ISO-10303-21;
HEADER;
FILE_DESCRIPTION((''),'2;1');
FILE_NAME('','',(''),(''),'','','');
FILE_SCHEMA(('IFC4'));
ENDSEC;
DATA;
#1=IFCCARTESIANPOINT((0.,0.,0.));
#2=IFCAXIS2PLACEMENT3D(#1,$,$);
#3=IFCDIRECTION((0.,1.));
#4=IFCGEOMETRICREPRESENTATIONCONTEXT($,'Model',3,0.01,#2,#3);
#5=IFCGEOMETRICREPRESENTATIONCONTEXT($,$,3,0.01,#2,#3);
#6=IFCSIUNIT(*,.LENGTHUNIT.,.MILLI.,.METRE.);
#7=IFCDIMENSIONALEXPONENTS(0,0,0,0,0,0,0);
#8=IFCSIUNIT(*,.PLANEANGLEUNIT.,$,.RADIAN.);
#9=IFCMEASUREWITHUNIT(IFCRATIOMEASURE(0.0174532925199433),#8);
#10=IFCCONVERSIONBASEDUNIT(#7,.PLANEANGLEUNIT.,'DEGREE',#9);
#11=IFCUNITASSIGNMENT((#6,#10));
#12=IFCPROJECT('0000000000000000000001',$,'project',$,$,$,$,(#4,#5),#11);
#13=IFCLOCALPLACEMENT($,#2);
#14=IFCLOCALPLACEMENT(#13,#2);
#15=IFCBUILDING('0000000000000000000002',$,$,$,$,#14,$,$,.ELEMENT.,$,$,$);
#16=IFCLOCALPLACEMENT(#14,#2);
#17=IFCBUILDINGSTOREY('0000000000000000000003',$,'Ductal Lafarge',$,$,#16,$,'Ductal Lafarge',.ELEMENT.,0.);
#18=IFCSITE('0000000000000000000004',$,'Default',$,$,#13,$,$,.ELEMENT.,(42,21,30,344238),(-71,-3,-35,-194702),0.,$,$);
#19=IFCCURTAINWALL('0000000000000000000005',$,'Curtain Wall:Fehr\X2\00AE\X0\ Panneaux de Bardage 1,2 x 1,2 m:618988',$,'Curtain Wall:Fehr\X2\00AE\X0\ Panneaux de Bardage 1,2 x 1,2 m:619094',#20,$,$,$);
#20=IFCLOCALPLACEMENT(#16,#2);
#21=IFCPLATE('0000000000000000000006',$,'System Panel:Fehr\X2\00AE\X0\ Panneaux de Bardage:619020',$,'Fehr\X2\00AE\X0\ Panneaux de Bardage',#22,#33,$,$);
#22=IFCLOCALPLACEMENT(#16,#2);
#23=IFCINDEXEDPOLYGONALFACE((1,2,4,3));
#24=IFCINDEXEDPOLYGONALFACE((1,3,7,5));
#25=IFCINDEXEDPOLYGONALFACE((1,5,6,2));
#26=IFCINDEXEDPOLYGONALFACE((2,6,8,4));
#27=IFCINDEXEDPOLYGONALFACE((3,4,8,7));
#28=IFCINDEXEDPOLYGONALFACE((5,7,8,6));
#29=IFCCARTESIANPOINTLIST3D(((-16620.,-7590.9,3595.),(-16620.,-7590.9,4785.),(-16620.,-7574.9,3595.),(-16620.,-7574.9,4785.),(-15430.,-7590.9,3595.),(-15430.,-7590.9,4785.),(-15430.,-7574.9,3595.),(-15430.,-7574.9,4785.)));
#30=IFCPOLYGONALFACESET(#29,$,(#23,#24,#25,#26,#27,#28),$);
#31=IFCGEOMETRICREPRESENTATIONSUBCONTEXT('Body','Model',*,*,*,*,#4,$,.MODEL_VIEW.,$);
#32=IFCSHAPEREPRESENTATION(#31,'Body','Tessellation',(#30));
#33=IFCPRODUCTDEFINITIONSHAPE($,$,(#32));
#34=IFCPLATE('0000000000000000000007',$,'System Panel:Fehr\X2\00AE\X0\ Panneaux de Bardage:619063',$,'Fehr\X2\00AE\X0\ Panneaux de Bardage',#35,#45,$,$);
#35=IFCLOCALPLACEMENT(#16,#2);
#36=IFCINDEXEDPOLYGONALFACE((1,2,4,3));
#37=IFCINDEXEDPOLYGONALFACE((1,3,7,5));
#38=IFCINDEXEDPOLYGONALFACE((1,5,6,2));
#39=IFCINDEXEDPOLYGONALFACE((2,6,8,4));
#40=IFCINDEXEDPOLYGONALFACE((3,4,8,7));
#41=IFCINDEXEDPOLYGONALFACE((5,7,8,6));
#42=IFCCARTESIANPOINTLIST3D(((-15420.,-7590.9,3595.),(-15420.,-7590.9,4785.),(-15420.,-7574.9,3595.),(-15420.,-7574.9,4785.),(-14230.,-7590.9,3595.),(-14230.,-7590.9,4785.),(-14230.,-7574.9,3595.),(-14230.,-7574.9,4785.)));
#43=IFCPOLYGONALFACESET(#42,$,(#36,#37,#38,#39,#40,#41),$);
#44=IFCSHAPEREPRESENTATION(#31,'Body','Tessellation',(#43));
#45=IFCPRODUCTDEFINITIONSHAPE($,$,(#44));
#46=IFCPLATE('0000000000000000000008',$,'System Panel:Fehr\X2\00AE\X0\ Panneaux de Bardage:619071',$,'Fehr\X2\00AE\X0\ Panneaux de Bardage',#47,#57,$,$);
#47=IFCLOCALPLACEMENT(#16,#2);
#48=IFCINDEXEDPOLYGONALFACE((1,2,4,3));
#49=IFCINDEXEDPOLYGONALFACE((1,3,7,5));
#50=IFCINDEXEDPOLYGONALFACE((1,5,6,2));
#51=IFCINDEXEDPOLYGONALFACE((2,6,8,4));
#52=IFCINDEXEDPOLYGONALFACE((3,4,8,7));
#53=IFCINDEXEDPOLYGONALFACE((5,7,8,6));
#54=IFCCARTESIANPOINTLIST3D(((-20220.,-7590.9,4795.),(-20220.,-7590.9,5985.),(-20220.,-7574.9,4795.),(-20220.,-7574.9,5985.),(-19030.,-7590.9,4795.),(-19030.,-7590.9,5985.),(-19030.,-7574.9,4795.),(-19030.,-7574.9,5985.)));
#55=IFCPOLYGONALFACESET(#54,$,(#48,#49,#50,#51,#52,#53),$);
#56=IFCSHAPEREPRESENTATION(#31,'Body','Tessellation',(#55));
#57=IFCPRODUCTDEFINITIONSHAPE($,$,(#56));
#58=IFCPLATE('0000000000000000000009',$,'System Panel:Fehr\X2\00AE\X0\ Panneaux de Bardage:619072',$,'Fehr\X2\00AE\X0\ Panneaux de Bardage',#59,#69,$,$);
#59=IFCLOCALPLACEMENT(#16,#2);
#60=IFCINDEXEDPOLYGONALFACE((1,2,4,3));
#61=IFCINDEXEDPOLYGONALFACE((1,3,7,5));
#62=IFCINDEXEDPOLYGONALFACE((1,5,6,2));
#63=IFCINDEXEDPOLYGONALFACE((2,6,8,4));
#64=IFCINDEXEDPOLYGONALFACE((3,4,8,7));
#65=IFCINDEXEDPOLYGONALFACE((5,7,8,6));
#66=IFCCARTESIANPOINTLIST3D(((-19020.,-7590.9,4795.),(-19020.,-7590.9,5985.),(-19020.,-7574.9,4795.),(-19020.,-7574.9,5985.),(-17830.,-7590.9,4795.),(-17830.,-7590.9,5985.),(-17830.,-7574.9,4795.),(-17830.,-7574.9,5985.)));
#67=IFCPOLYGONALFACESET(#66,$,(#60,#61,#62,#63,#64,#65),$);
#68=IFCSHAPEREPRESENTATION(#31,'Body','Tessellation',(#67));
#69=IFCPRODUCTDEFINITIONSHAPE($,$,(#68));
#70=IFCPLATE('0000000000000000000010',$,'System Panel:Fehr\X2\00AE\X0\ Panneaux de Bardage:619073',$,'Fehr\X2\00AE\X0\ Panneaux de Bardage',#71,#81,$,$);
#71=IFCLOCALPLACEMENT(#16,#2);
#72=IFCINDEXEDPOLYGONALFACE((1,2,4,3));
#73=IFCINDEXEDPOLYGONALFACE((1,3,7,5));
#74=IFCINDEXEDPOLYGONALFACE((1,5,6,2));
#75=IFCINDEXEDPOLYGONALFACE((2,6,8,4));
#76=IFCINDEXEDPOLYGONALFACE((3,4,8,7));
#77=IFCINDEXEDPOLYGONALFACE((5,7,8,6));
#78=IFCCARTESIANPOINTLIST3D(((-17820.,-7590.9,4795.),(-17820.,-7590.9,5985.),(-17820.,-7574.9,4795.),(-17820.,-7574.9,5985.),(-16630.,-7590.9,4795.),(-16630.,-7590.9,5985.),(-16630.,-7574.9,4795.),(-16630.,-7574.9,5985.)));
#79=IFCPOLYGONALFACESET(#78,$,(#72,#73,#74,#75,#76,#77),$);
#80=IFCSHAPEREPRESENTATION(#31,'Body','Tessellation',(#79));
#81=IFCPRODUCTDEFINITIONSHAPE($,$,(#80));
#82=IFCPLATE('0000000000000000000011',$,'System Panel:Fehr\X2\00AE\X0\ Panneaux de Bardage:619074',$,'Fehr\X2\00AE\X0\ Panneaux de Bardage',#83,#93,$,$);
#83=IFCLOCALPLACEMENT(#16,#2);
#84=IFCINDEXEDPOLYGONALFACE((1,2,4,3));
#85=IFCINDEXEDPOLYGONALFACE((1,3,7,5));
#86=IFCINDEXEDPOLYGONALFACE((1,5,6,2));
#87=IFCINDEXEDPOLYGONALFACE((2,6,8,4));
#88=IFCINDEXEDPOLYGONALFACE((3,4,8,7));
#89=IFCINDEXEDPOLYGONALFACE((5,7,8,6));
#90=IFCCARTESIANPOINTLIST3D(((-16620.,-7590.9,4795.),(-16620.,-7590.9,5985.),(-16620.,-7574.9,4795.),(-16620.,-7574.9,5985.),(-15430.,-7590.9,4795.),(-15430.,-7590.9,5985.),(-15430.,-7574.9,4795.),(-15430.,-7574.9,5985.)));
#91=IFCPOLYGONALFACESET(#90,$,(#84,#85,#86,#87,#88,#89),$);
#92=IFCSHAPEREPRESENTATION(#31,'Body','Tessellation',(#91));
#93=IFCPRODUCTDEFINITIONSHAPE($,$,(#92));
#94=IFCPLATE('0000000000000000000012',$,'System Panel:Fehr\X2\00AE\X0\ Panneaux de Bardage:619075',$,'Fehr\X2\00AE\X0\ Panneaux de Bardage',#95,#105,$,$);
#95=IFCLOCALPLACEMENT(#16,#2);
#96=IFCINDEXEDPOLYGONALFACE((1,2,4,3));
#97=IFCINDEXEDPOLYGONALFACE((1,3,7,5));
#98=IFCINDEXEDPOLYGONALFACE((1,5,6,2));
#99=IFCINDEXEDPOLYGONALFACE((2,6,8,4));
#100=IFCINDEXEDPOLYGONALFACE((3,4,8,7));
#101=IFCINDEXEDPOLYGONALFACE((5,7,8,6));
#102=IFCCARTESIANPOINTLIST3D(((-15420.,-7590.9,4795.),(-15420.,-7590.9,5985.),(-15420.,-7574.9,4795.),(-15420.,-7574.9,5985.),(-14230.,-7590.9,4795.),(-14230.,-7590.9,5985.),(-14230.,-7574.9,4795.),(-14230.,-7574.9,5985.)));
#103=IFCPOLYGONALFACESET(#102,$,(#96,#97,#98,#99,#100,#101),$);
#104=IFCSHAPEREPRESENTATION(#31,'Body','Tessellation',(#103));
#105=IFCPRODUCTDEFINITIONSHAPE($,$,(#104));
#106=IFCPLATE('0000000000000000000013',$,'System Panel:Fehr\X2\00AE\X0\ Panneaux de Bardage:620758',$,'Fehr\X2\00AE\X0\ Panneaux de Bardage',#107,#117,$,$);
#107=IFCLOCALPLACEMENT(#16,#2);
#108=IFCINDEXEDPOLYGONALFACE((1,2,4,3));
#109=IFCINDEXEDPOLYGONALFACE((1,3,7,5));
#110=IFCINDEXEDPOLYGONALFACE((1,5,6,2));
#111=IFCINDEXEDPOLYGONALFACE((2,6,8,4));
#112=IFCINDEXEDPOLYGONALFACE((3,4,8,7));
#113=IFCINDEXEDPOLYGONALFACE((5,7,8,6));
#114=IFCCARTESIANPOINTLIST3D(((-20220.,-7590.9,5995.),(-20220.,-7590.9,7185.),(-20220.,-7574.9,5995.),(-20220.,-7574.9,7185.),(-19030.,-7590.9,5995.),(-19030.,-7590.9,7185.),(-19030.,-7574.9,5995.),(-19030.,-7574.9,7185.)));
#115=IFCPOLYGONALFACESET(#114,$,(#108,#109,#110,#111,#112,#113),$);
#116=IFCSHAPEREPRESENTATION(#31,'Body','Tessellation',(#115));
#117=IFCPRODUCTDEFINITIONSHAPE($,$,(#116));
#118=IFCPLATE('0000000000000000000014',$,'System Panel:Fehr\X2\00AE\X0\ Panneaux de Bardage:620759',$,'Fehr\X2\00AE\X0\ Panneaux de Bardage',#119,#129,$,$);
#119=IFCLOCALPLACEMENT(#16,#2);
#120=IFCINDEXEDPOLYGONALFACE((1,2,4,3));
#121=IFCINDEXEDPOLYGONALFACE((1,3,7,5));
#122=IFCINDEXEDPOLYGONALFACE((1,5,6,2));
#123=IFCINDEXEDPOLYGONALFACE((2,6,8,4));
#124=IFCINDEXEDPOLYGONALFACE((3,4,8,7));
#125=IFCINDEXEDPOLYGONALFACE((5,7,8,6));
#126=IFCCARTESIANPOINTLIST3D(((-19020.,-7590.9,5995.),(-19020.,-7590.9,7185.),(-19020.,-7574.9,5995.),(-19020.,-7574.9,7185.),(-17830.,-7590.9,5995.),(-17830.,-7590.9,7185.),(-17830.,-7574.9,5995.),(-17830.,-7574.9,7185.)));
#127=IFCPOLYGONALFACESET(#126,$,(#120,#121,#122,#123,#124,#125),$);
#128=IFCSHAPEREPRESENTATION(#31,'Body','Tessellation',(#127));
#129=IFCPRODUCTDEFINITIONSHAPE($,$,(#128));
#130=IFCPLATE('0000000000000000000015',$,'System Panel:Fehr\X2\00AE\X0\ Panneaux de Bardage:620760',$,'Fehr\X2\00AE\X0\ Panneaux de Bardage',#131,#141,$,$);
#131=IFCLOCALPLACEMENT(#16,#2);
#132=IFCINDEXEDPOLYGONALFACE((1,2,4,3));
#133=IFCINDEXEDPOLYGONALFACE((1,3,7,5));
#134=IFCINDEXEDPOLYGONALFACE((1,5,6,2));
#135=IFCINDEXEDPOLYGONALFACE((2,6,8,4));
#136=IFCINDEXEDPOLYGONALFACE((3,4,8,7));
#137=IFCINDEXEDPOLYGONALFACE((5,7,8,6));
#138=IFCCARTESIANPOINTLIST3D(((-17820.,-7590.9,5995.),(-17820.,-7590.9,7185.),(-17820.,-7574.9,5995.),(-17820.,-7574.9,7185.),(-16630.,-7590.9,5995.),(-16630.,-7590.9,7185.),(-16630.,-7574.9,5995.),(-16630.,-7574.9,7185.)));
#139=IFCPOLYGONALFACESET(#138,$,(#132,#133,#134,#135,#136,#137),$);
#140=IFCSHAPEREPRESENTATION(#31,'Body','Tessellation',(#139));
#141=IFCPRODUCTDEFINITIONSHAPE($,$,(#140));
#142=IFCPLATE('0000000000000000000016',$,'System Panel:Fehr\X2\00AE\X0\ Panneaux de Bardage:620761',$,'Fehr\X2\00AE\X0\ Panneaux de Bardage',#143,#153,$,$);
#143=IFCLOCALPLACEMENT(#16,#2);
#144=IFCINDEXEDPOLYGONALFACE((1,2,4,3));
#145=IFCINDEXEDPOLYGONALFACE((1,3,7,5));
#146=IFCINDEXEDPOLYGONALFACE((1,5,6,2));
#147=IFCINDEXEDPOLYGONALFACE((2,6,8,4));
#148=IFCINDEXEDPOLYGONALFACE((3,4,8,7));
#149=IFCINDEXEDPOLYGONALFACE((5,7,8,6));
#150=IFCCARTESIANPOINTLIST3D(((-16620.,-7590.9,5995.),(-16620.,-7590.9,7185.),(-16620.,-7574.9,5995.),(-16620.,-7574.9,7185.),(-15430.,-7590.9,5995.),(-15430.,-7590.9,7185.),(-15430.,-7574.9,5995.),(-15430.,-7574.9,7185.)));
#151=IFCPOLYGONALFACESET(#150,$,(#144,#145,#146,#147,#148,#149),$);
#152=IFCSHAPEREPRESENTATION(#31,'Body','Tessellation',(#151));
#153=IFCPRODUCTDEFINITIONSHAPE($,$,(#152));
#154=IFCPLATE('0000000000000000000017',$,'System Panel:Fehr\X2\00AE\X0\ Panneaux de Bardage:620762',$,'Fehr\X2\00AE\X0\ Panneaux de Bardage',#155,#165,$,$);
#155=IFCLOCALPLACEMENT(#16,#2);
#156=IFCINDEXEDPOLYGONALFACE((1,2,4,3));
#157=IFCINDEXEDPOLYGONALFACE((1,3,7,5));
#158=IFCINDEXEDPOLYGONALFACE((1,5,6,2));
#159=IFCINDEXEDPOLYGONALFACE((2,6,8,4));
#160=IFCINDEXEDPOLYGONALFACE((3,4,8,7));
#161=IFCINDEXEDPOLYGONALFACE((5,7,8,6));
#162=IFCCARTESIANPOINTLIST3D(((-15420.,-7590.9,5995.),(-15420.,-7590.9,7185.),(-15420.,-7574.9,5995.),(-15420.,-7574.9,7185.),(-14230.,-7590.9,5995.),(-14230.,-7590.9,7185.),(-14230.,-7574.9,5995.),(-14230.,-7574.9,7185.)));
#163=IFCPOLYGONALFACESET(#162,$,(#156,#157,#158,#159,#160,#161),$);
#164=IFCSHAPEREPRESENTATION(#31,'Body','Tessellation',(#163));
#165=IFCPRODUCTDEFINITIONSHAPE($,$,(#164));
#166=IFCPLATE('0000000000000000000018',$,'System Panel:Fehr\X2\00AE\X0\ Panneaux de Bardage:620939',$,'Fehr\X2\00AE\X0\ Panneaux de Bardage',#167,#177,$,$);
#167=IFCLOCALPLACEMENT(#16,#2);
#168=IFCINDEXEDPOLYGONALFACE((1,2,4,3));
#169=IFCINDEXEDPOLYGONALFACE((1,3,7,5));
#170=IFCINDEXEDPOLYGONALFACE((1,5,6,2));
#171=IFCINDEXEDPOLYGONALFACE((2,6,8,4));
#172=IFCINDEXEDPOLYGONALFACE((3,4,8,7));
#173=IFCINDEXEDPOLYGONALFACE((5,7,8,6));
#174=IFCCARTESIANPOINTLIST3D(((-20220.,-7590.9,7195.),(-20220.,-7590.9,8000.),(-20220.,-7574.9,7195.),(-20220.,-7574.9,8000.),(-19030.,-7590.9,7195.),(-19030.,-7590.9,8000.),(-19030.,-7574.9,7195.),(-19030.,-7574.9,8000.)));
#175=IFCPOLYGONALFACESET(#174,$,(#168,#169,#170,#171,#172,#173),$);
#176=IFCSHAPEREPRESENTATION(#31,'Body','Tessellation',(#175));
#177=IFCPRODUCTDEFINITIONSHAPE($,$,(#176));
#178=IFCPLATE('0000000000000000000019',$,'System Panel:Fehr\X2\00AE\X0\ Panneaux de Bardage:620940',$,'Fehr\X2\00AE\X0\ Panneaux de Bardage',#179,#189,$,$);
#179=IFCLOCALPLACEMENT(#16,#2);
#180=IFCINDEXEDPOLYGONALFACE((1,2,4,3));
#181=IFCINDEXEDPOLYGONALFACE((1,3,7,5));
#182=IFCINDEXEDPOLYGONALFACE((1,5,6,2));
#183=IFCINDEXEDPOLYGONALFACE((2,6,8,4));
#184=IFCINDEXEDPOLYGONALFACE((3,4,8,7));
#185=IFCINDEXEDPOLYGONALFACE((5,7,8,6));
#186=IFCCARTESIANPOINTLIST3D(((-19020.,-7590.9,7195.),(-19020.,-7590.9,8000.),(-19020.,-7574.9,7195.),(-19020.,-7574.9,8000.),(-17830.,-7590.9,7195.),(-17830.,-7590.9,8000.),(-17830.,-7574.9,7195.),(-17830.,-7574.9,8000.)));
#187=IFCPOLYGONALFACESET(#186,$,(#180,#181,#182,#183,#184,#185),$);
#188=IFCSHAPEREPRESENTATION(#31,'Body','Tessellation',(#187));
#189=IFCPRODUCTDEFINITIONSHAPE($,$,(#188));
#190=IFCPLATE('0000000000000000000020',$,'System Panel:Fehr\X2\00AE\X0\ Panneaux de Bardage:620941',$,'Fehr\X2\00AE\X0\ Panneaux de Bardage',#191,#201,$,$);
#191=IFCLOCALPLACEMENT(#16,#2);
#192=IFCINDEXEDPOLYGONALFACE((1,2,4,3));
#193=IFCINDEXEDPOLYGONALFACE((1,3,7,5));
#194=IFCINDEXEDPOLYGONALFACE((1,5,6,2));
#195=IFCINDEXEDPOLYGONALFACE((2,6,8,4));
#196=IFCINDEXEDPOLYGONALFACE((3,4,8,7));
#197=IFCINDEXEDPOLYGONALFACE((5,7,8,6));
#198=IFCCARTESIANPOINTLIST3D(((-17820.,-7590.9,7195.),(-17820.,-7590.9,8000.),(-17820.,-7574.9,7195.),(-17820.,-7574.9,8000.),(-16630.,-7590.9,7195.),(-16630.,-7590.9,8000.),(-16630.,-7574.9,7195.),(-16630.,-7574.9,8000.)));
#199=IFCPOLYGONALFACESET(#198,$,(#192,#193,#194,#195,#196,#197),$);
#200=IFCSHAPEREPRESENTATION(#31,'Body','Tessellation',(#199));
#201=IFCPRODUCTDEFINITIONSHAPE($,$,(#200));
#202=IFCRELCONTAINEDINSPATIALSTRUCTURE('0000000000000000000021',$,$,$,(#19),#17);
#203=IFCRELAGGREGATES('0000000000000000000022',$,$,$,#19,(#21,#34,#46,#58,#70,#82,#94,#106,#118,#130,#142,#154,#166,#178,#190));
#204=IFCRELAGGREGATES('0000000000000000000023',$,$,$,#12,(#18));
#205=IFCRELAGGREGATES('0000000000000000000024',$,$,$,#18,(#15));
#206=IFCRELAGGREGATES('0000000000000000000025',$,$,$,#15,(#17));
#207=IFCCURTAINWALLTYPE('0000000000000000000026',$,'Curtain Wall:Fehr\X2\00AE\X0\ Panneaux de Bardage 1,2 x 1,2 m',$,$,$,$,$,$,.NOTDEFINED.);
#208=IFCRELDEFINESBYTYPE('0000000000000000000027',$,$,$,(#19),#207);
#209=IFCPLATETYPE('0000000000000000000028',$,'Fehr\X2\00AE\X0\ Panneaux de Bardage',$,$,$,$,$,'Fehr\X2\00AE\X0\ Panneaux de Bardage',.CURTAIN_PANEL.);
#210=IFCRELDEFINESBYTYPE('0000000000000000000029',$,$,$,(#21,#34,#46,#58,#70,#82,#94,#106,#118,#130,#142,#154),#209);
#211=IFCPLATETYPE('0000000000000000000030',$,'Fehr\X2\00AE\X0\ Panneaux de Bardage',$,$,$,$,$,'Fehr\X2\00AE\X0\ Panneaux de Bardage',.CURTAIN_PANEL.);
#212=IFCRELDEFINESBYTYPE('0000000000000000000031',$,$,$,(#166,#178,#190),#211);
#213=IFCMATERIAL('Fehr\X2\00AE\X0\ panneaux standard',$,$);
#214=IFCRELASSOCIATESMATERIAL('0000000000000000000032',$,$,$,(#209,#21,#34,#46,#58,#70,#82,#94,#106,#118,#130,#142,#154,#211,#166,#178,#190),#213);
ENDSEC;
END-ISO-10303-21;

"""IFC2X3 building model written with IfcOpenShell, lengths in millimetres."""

from ifc_helpers import new_model, entity, si_unit, converted_unit, direction, frame, origin, origin_2d_with_axis, place, context, subcontext, project, spatial, rectangle, extrude, source, transform, mapped, material, type_object, type_shapes, element, aggregate, save


model = new_model("IFC2X3")

# Units and contexts
model_context = context("Model", 3, precision=0.01, world=origin(), true_north=direction((0.0, 1.0)))
context_of_model = context(None, 3, precision=0.01, world=origin(), true_north=direction((0.0, 1.0)))
body_context = subcontext(model_context, "Body", "Model", "MODEL_VIEW")
ifc_project = project(units=[si_unit("LENGTHUNIT", "METRE", prefix="MILLI"), converted_unit("PLANEANGLEUNIT", "DEGREE", entity("IfcRatioMeasure", 0.0174532925199433), si_unit("PLANEANGLEUNIT", "RADIAN"), dimensions=[0, 0, 0, 0, 0, 0, 0])], contexts=[model_context, context_of_model])

# Site, building, storey
site_placement = place(None, origin())
site = spatial("IfcSite", under=ifc_project, at=site_placement, Name="Default", CompositionType="ELEMENT", RefLatitude=(42, 21, 30, 344238), RefLongitude=(-71, -3, -35, -194702), RefElevation=0.0)
building_placement = place(site_placement, origin())
building = spatial("IfcBuilding", under=site, at=building_placement, CompositionType="ELEMENT")
storey_placement = place(building_placement, origin())
storey = spatial("IfcBuildingStorey", under=building, at=storey_placement, Name="Ductal Lafarge", LongName="Ductal Lafarge", CompositionType="ELEMENT", Elevation=0.0)

# Curtain wall, plates
curtain_wall_type = type_object("IfcCurtainWallType", Name="Curtain Wall:Fehr® Panneaux de Bardage 1,2 x 1,2 m", PredefinedType="NOTDEFINED")
curtain_wall_placement = place(storey_placement, origin())
curtain_wall = element("IfcCurtainWall", 1, at=curtain_wall_placement, inside=storey, type_object=curtain_wall_type, Name="Curtain Wall:Fehr® Panneaux de Bardage 1,2 x 1,2 m:618988", ObjectType="Curtain Wall:Fehr® Panneaux de Bardage 1,2 x 1,2 m:619094")
ifc_material_1 = material(Name="Fehr® panneaux standard")
plate_type_1 = type_object("IfcPlateType", Name="Fehr® Panneaux de Bardage", ElementType="Fehr® Panneaux de Bardage", PredefinedType="CURTAIN_PANEL", material=ifc_material_1)
shared_shape_1 = source(origin(), body_context, "Body", "SweptSolid", [
    extrude(rectangle(XDim=16.0, YDim=1190.0, at=origin_2d_with_axis()), frame((0.0, 0.0, 0.0), z_axis=(0.0, 0.0, 1.0), x_axis=(0.0, 1.0, 0.0)), (0.0, 0.0, 1.0), 1190.0),
])
type_shapes(plate_type_1, [shared_shape_1])
plate_1_placement = place(curtain_wall_placement, frame((-16025.0, -7582.9, 3595.0)))
plate_1 = element("IfcPlate", 2, at=plate_1_placement, type_object=plate_type_1, material=ifc_material_1, Name="System Panel:Fehr® Panneaux de Bardage:619020", ObjectType="Fehr® Panneaux de Bardage", context=body_context, shape_type="MappedRepresentation", body=[
    mapped(shared_shape_1, transform((0.0, 0.0, 0.0), scale=1.0)),
])
plate_2_placement = place(curtain_wall_placement, frame((-14825.0, -7582.9, 3595.0)))
plate_2 = element("IfcPlate", 3, at=plate_2_placement, type_object=plate_type_1, material=ifc_material_1, Name="System Panel:Fehr® Panneaux de Bardage:619063", ObjectType="Fehr® Panneaux de Bardage", context=body_context, shape_type="MappedRepresentation", body=[
    mapped(shared_shape_1, transform((0.0, 0.0, 0.0), scale=1.0)),
])
plate_3_placement = place(curtain_wall_placement, frame((-19625.0, -7582.9, 4795.0)))
plate_3 = element("IfcPlate", 4, at=plate_3_placement, type_object=plate_type_1, material=ifc_material_1, Name="System Panel:Fehr® Panneaux de Bardage:619071", ObjectType="Fehr® Panneaux de Bardage", context=body_context, shape_type="MappedRepresentation", body=[
    mapped(shared_shape_1, transform((0.0, 0.0, 0.0), scale=1.0)),
])
plate_4_placement = place(curtain_wall_placement, frame((-18425.0, -7582.9, 4795.0)))
plate_4 = element("IfcPlate", 5, at=plate_4_placement, type_object=plate_type_1, material=ifc_material_1, Name="System Panel:Fehr® Panneaux de Bardage:619072", ObjectType="Fehr® Panneaux de Bardage", context=body_context, shape_type="MappedRepresentation", body=[
    mapped(shared_shape_1, transform((0.0, 0.0, 0.0), scale=1.0)),
])
plate_5_placement = place(curtain_wall_placement, frame((-17225.0, -7582.9, 4795.0)))
plate_5 = element("IfcPlate", 6, at=plate_5_placement, type_object=plate_type_1, material=ifc_material_1, Name="System Panel:Fehr® Panneaux de Bardage:619073", ObjectType="Fehr® Panneaux de Bardage", context=body_context, shape_type="MappedRepresentation", body=[
    mapped(shared_shape_1, transform((0.0, 0.0, 0.0), scale=1.0)),
])
plate_6_placement = place(curtain_wall_placement, frame((-16025.0, -7582.9, 4795.0)))
plate_6 = element("IfcPlate", 7, at=plate_6_placement, type_object=plate_type_1, material=ifc_material_1, Name="System Panel:Fehr® Panneaux de Bardage:619074", ObjectType="Fehr® Panneaux de Bardage", context=body_context, shape_type="MappedRepresentation", body=[
    mapped(shared_shape_1, transform((0.0, 0.0, 0.0), scale=1.0)),
])
plate_7_placement = place(curtain_wall_placement, frame((-14825.0, -7582.9, 4795.0)))
plate_7 = element("IfcPlate", 8, at=plate_7_placement, type_object=plate_type_1, material=ifc_material_1, Name="System Panel:Fehr® Panneaux de Bardage:619075", ObjectType="Fehr® Panneaux de Bardage", context=body_context, shape_type="MappedRepresentation", body=[
    mapped(shared_shape_1, transform((0.0, 0.0, 0.0), scale=1.0)),
])
plate_8_placement = place(curtain_wall_placement, frame((-19625.0, -7582.9, 5995.0)))
plate_8 = element("IfcPlate", 9, at=plate_8_placement, type_object=plate_type_1, material=ifc_material_1, Name="System Panel:Fehr® Panneaux de Bardage:620758", ObjectType="Fehr® Panneaux de Bardage", context=body_context, shape_type="MappedRepresentation", body=[
    mapped(shared_shape_1, transform((0.0, 0.0, 0.0), scale=1.0)),
])
plate_9_placement = place(curtain_wall_placement, frame((-18425.0, -7582.9, 5995.0)))
plate_9 = element("IfcPlate", 10, at=plate_9_placement, type_object=plate_type_1, material=ifc_material_1, Name="System Panel:Fehr® Panneaux de Bardage:620759", ObjectType="Fehr® Panneaux de Bardage", context=body_context, shape_type="MappedRepresentation", body=[
    mapped(shared_shape_1, transform((0.0, 0.0, 0.0), scale=1.0)),
])
plate_10_placement = place(curtain_wall_placement, frame((-17225.0, -7582.9, 5995.0)))
plate_10 = element("IfcPlate", 11, at=plate_10_placement, type_object=plate_type_1, material=ifc_material_1, Name="System Panel:Fehr® Panneaux de Bardage:620760", ObjectType="Fehr® Panneaux de Bardage", context=body_context, shape_type="MappedRepresentation", body=[
    mapped(shared_shape_1, transform((0.0, 0.0, 0.0), scale=1.0)),
])
plate_11_placement = place(curtain_wall_placement, frame((-16025.0, -7582.9, 5995.0)))
plate_11 = element("IfcPlate", 12, at=plate_11_placement, type_object=plate_type_1, material=ifc_material_1, Name="System Panel:Fehr® Panneaux de Bardage:620761", ObjectType="Fehr® Panneaux de Bardage", context=body_context, shape_type="MappedRepresentation", body=[
    mapped(shared_shape_1, transform((0.0, 0.0, 0.0), scale=1.0)),
])
plate_12_placement = place(curtain_wall_placement, frame((-14825.0, -7582.9, 5995.0)))
plate_12 = element("IfcPlate", 13, at=plate_12_placement, type_object=plate_type_1, material=ifc_material_1, Name="System Panel:Fehr® Panneaux de Bardage:620762", ObjectType="Fehr® Panneaux de Bardage", context=body_context, shape_type="MappedRepresentation", body=[
    mapped(shared_shape_1, transform((0.0, 0.0, 0.0), scale=1.0)),
])
plate_type_2 = type_object("IfcPlateType", Name="Fehr® Panneaux de Bardage", ElementType="Fehr® Panneaux de Bardage", PredefinedType="CURTAIN_PANEL", material=ifc_material_1)
shared_shape_2 = source(origin(), body_context, "Body", "SweptSolid", [
    extrude(rectangle(XDim=16.0, YDim=1190.0, at=origin_2d_with_axis()), frame((0.0, 0.0, 0.0), z_axis=(0.0, 0.0, 1.0), x_axis=(0.0, 1.0, 0.0)), (0.0, 0.0, 1.0), 805.0),
])
type_shapes(plate_type_2, [shared_shape_2])
plate_13_placement = place(curtain_wall_placement, frame((-19625.0, -7582.9, 7195.0)))
plate_13 = element("IfcPlate", 14, at=plate_13_placement, type_object=plate_type_2, material=ifc_material_1, Name="System Panel:Fehr® Panneaux de Bardage:620939", ObjectType="Fehr® Panneaux de Bardage", context=body_context, shape_type="MappedRepresentation", body=[
    mapped(shared_shape_2, transform((0.0, 0.0, 0.0), scale=1.0)),
])
plate_14_placement = place(curtain_wall_placement, frame((-18425.0, -7582.9, 7195.0)))
plate_14 = element("IfcPlate", 15, at=plate_14_placement, type_object=plate_type_2, material=ifc_material_1, Name="System Panel:Fehr® Panneaux de Bardage:620940", ObjectType="Fehr® Panneaux de Bardage", context=body_context, shape_type="MappedRepresentation", body=[
    mapped(shared_shape_2, transform((0.0, 0.0, 0.0), scale=1.0)),
])
plate_15_placement = place(curtain_wall_placement, frame((-17225.0, -7582.9, 7195.0)))
plate_15 = element("IfcPlate", 16, at=plate_15_placement, type_object=plate_type_2, material=ifc_material_1, Name="System Panel:Fehr® Panneaux de Bardage:620941", ObjectType="Fehr® Panneaux de Bardage", context=body_context, shape_type="MappedRepresentation", body=[
    mapped(shared_shape_2, transform((0.0, 0.0, 0.0), scale=1.0)),
])
aggregate(curtain_wall, [plate_1, plate_2, plate_3, plate_4, plate_5, plate_6, plate_7, plate_8, plate_9, plate_10, plate_11, plate_12, plate_13, plate_14, plate_15])

save(model, "model.ifc")
